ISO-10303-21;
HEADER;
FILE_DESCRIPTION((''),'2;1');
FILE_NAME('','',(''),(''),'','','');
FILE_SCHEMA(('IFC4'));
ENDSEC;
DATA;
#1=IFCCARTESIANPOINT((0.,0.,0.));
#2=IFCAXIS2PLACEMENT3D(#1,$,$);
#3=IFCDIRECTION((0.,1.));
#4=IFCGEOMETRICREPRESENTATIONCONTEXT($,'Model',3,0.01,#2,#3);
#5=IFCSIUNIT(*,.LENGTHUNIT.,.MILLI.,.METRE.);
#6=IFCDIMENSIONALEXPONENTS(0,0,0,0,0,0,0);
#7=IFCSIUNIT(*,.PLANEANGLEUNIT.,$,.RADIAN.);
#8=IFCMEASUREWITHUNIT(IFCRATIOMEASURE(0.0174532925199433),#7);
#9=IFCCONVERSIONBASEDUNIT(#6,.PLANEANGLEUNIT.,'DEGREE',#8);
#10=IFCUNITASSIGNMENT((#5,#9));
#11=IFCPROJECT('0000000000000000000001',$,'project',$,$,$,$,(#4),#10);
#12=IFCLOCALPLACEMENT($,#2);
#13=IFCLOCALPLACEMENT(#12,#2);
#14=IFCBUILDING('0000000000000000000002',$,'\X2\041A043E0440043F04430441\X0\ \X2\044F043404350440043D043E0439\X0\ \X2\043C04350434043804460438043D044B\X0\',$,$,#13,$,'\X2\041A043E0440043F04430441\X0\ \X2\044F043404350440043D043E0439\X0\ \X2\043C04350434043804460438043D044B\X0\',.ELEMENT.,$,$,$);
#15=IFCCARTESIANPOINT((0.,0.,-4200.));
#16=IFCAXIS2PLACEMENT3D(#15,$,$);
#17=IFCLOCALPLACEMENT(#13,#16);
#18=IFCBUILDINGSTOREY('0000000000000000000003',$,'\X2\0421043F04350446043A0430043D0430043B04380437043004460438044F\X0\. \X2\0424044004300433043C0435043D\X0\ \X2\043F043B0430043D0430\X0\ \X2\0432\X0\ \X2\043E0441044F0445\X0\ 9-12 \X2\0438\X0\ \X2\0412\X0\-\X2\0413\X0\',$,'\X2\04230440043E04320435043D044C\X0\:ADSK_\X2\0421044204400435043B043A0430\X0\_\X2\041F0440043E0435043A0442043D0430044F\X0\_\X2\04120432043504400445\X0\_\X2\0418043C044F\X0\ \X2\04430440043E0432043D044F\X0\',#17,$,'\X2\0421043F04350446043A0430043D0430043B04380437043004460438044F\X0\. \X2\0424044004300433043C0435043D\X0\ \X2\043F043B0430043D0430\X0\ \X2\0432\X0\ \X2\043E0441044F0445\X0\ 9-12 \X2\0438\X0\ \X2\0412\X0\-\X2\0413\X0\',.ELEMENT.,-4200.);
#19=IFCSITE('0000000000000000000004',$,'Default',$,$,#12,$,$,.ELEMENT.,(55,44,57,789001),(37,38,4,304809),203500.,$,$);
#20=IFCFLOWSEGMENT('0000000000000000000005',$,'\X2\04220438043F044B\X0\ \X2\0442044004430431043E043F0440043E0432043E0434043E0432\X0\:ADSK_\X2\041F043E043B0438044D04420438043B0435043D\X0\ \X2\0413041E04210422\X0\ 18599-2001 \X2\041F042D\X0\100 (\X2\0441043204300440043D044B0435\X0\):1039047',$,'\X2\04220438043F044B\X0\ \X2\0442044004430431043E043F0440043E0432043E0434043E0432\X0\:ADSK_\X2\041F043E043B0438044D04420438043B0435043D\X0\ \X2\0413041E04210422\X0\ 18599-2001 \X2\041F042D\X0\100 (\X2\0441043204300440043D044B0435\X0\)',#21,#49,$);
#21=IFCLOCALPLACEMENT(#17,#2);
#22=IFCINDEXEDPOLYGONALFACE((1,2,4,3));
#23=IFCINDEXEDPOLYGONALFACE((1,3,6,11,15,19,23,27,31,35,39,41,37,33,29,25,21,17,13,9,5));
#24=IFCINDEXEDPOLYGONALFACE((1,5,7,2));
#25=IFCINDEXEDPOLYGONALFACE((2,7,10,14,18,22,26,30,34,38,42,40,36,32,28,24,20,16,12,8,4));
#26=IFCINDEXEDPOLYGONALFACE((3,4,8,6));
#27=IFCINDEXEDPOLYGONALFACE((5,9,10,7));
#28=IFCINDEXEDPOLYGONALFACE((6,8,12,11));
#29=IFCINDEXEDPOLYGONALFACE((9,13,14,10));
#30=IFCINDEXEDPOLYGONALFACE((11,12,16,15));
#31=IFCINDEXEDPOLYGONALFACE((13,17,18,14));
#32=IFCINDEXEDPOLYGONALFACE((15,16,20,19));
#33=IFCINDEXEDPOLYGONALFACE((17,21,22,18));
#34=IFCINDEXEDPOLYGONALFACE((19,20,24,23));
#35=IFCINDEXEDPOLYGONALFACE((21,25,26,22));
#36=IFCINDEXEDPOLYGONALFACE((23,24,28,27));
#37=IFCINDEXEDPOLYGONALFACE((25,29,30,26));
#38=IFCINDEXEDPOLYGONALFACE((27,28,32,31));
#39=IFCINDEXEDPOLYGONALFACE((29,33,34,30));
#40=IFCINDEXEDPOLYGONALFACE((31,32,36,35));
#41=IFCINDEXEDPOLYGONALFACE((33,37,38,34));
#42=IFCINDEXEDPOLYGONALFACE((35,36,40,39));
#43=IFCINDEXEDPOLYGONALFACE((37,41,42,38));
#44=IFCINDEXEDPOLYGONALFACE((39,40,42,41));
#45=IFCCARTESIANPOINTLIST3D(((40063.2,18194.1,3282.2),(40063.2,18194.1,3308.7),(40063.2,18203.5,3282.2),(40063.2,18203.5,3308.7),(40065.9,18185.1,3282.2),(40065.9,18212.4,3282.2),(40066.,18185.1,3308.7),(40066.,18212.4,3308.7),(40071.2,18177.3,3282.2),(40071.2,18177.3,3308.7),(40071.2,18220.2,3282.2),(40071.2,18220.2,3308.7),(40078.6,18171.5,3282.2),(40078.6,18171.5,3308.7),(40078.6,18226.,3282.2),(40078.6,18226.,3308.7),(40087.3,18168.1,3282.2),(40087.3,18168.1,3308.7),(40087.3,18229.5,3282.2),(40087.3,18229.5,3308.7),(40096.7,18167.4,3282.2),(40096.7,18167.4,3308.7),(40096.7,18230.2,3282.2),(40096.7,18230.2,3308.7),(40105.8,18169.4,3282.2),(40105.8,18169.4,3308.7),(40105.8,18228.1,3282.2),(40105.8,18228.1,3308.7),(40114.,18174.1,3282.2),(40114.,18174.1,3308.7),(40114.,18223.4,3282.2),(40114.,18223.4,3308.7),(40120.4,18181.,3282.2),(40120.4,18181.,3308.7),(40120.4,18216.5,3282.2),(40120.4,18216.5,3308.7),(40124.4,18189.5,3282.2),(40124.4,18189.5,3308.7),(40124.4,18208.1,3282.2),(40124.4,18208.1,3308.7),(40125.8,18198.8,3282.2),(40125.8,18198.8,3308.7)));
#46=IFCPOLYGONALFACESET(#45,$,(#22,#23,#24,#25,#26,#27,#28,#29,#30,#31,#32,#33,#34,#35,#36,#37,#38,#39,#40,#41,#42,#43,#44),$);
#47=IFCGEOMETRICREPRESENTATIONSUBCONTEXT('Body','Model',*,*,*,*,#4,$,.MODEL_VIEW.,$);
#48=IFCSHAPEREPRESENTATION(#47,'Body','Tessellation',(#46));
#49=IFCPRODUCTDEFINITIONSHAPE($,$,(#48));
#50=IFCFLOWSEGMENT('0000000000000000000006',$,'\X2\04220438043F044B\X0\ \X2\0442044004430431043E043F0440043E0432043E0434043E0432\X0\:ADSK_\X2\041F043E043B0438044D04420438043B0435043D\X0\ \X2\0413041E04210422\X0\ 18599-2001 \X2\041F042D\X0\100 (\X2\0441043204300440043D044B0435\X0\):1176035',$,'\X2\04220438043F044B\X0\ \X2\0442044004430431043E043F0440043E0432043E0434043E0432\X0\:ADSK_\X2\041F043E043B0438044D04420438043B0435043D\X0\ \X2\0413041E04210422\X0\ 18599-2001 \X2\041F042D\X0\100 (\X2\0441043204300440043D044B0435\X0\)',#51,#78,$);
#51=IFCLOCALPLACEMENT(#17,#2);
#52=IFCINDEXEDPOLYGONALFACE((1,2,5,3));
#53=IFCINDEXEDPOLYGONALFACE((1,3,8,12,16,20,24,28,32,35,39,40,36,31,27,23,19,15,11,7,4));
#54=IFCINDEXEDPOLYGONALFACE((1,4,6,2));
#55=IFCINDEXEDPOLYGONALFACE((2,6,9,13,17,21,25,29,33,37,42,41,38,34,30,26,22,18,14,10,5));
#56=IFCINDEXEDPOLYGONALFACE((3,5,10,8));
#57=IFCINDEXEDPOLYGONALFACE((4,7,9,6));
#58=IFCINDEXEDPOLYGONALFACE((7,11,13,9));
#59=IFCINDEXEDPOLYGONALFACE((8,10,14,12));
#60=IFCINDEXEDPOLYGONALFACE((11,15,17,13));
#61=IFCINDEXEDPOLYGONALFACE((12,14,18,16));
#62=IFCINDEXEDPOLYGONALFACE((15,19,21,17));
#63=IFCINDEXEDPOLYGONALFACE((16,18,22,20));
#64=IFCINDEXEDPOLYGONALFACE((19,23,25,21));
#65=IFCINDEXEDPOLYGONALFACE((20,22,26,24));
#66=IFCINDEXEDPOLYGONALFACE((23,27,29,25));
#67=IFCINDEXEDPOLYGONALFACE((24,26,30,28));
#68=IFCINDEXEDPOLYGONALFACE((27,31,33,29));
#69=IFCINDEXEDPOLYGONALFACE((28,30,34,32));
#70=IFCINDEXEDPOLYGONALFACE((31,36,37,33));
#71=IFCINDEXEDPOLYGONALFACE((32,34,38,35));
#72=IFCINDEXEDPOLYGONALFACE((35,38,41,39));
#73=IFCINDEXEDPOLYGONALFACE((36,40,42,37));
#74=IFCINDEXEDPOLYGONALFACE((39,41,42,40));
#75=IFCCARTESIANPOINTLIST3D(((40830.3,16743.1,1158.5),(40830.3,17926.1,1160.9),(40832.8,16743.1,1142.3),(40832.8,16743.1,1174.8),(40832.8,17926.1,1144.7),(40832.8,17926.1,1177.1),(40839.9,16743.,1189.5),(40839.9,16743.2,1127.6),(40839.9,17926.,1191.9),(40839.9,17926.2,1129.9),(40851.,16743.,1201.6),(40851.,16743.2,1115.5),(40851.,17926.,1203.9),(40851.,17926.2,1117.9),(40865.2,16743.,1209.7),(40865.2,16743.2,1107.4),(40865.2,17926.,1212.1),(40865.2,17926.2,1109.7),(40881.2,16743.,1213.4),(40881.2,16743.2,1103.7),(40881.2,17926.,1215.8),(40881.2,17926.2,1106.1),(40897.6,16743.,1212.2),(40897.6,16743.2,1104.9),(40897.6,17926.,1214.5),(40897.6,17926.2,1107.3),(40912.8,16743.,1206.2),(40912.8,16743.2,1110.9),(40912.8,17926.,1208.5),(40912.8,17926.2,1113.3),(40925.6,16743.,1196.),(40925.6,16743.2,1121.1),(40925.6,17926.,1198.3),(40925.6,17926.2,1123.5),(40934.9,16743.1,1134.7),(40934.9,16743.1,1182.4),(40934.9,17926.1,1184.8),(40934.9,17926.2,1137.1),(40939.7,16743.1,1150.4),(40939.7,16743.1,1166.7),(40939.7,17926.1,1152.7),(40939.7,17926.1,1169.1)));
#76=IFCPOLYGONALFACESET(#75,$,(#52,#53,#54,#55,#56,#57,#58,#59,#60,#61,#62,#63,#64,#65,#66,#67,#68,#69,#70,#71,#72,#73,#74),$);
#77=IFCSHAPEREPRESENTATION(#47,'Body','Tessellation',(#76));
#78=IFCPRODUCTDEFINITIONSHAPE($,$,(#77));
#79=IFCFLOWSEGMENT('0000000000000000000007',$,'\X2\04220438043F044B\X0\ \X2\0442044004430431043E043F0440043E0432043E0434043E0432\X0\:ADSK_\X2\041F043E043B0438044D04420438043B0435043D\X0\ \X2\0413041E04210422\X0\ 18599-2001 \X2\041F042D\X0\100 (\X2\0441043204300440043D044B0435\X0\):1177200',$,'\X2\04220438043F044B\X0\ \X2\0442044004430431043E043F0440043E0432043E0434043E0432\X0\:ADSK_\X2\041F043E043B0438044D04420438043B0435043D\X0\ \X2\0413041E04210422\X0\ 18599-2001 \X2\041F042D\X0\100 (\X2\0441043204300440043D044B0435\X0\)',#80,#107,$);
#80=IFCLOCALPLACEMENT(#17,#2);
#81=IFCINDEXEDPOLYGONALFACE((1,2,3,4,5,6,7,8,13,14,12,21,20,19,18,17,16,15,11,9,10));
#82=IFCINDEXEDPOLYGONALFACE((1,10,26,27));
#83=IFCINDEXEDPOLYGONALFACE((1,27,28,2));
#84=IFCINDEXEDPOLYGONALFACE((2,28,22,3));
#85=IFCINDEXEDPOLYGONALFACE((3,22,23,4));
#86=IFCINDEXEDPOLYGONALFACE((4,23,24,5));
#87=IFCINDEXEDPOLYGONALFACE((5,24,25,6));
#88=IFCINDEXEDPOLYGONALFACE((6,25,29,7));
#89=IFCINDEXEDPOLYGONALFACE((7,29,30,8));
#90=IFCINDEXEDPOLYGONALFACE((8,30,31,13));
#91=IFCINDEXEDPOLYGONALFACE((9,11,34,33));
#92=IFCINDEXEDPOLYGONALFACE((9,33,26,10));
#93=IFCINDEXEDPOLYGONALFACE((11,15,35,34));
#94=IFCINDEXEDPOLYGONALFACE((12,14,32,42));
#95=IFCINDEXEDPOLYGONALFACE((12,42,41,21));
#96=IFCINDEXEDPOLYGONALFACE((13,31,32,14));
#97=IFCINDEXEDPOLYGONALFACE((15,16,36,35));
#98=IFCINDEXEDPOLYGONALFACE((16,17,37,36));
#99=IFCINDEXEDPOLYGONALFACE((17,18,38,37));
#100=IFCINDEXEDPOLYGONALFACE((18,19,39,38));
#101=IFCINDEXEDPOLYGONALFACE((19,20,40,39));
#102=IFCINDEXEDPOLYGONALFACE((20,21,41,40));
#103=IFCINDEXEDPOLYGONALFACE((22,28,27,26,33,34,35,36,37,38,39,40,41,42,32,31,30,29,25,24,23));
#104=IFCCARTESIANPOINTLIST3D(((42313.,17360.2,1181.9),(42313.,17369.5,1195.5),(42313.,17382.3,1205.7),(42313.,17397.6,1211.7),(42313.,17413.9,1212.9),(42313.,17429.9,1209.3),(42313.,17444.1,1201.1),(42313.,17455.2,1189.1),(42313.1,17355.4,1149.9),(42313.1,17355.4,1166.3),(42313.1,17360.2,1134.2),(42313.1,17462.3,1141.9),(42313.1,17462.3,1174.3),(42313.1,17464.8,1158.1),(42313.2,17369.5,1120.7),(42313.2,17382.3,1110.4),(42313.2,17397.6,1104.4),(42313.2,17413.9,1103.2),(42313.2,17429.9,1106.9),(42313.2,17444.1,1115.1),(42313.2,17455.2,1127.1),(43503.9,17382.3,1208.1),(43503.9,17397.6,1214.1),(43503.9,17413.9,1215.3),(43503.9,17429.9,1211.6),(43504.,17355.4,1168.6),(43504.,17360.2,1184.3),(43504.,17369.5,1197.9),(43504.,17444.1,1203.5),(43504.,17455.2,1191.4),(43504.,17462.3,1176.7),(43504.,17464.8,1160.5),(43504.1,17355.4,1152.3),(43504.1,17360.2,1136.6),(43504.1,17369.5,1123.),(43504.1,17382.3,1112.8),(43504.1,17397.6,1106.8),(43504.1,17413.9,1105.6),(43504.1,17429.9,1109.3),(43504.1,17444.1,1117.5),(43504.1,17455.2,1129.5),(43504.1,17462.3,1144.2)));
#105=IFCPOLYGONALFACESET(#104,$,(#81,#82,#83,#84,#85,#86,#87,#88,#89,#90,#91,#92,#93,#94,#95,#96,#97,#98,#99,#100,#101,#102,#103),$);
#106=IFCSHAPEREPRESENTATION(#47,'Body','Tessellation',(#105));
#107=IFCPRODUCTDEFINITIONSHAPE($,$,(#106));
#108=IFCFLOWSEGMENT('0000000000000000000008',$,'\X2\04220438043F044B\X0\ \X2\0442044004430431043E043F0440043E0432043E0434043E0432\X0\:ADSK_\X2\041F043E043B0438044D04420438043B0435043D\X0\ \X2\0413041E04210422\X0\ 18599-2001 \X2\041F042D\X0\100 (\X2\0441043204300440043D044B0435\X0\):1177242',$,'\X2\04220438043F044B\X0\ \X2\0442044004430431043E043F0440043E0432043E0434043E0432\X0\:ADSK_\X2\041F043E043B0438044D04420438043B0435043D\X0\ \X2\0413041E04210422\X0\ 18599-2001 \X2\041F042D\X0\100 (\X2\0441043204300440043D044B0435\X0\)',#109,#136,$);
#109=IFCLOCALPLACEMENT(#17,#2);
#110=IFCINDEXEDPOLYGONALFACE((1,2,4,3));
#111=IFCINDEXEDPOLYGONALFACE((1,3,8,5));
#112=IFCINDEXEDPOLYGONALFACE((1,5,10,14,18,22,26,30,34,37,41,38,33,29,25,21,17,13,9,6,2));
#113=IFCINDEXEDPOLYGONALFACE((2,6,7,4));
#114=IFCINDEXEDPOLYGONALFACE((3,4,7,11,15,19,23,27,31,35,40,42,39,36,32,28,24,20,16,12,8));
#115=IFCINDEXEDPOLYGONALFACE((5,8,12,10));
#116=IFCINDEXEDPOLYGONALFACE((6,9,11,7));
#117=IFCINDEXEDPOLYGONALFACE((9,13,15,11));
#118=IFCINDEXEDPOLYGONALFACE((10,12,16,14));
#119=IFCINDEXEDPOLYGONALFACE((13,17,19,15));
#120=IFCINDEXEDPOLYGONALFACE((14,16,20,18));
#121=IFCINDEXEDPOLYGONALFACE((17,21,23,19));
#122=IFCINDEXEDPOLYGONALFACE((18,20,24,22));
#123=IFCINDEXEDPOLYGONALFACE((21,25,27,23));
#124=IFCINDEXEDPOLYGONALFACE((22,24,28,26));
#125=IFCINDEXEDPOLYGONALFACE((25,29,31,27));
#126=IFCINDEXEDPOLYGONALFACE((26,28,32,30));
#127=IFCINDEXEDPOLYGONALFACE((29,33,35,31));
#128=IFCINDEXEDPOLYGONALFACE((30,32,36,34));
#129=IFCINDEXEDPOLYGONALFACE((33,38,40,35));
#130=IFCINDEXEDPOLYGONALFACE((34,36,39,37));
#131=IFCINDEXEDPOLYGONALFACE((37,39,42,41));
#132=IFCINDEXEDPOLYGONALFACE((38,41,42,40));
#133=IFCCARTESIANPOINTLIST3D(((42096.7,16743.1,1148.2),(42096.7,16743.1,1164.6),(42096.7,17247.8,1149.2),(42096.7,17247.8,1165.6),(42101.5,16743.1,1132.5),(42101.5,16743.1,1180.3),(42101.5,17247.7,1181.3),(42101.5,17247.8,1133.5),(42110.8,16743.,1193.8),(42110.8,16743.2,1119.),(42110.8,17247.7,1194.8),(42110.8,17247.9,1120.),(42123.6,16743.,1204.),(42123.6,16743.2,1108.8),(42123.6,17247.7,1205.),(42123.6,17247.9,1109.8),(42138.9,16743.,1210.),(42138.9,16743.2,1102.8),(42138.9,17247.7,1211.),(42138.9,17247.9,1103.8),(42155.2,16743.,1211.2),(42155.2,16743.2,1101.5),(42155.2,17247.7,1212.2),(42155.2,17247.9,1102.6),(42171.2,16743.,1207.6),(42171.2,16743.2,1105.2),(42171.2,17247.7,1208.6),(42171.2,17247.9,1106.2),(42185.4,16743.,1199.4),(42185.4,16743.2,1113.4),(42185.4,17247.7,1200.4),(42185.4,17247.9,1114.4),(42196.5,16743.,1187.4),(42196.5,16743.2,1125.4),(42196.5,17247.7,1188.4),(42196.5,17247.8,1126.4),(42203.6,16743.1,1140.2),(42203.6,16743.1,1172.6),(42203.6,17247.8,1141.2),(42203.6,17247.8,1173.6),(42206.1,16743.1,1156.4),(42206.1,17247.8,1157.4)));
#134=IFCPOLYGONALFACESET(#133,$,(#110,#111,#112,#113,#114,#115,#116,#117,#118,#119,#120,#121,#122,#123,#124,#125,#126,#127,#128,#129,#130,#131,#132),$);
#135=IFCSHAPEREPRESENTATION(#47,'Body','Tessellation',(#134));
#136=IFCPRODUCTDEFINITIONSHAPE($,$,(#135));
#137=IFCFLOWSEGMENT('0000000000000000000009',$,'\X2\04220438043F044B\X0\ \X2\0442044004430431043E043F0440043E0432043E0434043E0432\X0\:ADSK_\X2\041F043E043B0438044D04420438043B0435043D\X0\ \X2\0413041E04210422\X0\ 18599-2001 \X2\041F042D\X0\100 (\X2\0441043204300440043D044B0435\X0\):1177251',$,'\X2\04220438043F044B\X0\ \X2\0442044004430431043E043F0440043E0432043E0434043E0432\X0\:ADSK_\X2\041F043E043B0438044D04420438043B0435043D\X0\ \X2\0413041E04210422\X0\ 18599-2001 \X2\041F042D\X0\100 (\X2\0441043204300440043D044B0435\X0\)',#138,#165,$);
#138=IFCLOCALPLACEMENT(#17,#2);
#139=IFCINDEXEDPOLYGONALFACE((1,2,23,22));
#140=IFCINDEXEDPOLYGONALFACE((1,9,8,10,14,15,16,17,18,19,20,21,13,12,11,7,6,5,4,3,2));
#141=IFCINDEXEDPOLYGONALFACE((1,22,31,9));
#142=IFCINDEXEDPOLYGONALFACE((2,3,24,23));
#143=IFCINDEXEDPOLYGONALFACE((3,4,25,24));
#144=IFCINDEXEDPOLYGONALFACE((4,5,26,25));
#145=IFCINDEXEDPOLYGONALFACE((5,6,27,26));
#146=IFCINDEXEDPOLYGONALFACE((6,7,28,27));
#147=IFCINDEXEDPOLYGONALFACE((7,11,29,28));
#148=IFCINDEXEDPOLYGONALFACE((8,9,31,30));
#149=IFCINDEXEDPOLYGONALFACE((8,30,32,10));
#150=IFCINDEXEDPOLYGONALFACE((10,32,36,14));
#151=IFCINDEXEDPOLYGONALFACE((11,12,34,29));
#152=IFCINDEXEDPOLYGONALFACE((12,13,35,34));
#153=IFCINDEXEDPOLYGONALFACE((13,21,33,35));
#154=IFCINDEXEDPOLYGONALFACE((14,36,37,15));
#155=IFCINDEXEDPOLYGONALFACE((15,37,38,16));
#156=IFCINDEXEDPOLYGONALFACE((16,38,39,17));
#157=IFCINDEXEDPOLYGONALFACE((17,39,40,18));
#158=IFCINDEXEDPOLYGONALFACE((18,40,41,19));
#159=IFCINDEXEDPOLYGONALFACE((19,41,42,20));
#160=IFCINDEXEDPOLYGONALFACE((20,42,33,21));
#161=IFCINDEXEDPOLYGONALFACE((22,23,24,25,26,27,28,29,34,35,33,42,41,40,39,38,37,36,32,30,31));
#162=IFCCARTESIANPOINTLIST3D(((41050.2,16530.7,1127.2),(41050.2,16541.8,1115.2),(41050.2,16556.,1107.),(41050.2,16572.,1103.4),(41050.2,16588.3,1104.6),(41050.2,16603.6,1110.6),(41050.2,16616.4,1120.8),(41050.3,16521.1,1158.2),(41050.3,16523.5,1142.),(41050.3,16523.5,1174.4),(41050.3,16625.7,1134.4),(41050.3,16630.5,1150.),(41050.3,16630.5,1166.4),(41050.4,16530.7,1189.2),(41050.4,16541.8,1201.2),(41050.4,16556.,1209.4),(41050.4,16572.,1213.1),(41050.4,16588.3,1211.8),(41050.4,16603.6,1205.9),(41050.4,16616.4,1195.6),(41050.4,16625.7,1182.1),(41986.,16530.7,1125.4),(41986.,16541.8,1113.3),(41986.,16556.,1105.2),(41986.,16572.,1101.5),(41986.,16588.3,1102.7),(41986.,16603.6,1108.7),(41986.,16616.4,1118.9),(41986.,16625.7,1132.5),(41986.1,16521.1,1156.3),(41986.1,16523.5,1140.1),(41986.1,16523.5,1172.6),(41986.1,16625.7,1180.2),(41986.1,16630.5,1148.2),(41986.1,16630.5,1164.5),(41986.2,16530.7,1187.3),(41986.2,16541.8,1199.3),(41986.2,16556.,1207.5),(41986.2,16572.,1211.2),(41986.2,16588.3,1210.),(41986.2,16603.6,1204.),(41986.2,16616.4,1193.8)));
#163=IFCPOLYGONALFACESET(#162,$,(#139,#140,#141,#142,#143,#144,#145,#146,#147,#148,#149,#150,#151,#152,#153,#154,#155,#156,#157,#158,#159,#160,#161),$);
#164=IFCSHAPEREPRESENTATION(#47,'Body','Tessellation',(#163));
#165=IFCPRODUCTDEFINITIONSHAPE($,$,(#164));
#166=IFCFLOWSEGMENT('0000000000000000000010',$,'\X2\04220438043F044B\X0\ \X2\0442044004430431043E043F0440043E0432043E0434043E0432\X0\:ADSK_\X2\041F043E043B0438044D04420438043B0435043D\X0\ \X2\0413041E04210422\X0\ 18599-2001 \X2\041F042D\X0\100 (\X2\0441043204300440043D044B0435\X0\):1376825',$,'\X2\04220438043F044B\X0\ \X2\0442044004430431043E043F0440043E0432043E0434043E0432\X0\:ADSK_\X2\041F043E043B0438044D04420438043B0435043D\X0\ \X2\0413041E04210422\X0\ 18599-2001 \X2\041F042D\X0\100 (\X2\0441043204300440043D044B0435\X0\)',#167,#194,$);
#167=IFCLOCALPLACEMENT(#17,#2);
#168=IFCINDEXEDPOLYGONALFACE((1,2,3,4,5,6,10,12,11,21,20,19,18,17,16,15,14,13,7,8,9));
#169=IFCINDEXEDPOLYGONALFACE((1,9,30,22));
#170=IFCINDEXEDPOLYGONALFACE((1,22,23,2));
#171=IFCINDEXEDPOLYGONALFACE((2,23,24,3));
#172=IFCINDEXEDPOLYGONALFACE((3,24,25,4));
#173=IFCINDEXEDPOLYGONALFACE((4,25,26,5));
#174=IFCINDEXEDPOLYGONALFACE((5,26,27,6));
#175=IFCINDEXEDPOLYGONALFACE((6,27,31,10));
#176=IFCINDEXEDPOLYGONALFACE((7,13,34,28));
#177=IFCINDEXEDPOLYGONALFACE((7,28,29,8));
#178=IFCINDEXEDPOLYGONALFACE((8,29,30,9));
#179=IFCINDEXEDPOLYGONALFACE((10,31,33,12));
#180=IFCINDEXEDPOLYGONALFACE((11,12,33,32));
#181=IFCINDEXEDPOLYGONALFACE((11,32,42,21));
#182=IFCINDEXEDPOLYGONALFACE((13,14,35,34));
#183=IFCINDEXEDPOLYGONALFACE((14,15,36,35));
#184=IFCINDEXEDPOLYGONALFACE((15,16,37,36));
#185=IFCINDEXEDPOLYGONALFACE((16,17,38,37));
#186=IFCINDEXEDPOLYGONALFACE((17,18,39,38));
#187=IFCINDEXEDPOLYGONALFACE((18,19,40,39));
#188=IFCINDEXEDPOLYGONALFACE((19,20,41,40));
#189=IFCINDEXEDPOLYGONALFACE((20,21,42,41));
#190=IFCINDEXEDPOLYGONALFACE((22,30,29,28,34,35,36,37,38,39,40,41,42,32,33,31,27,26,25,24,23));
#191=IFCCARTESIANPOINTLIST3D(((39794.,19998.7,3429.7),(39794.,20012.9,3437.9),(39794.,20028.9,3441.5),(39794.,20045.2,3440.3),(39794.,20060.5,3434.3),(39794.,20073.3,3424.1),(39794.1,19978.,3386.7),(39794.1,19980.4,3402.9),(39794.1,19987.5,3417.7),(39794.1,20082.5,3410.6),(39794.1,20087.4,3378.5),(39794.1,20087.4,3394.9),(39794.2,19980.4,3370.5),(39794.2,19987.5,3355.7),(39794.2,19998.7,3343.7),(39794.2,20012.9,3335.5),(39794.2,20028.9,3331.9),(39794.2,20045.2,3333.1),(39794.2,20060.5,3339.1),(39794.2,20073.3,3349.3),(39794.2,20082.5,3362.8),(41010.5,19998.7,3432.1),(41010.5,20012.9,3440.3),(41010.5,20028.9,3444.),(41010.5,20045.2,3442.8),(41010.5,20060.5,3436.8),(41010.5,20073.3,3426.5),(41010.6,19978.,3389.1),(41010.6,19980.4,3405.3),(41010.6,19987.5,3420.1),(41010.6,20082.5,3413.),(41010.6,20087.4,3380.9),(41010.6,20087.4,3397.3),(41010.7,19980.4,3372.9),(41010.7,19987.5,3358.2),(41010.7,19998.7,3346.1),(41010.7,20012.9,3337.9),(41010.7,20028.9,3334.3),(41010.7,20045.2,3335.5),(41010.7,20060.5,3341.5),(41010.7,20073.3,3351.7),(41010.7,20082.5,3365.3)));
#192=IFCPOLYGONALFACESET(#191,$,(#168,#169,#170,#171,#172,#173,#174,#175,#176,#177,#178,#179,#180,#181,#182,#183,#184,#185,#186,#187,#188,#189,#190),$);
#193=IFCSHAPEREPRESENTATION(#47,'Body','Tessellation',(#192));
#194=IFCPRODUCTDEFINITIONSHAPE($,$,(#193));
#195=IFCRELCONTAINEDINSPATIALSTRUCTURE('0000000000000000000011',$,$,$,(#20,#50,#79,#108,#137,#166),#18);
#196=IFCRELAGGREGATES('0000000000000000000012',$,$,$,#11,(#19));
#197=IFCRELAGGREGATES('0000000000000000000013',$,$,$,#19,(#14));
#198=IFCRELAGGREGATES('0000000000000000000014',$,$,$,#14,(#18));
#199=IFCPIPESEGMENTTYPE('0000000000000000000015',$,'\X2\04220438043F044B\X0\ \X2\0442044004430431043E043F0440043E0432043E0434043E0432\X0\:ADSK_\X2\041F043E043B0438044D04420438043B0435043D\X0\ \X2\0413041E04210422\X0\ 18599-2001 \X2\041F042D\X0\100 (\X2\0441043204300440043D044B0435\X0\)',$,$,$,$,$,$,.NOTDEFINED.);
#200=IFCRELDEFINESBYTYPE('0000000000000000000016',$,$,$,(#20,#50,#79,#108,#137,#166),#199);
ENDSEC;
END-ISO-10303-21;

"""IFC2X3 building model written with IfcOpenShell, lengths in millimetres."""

from ifc_helpers import new_model, entity, si_unit, converted_unit, direction, frame, origin, origin_2d_with_axis, place, context, subcontext, project, spatial, circle, extrude, type_object, element, save


model = new_model("IFC2X3")

# Units and contexts
model_context = context("Model", 3, precision=0.01, world=origin(), true_north=direction((0.0, 1.0)))
body_context = subcontext(model_context, "Body", "Model", "MODEL_VIEW")
ifc_project = project(units=[si_unit("LENGTHUNIT", "METRE", prefix="MILLI"), converted_unit("PLANEANGLEUNIT", "DEGREE", entity("IfcRatioMeasure", 0.0174532925199433), si_unit("PLANEANGLEUNIT", "RADIAN"), dimensions=[0, 0, 0, 0, 0, 0, 0])], contexts=[model_context])

# Site, building, storey
site_placement = place(None, origin())
site = spatial("IfcSite", under=ifc_project, at=site_placement, Name="Default", CompositionType="ELEMENT", RefLatitude=(55, 44, 57, 789001), RefLongitude=(37, 38, 4, 304809), RefElevation=203500.0)
building_placement = place(site_placement, origin())
building = spatial("IfcBuilding", under=site, at=building_placement, Name="Корпус ядерной медицины", LongName="Корпус ядерной медицины", CompositionType="ELEMENT")
storey_placement = place(building_placement, frame((0.0, 0.0, -4200.0)))
storey = spatial("IfcBuildingStorey", under=building, at=storey_placement, Name="Спецканализация. Фрагмен плана в осях 9-12 и В-Г", ObjectType="Уровень:ADSK_Стрелка_Проектная_Вверх_Имя уровня", LongName="Спецканализация. Фрагмен плана в осях 9-12 и В-Г", CompositionType="ELEMENT", Elevation=-4200.0)

# Flow segments
pipe_segment_type = type_object("IfcPipeSegmentType", Name="Типы трубопроводов:ADSK_Полиэтилен ГОСТ 18599-2001 ПЭ100 (сварные)", PredefinedType="NOTDEFINED")
flow_segment_1_placement = place(storey_placement, frame((40061.2, 18165.7, 3282.2)))
element("IfcFlowSegment", 1, at=flow_segment_1_placement, inside=storey, type_object=pipe_segment_type, Name="Типы трубопроводов:ADSK_Полиэтилен ГОСТ 18599-2001 ПЭ100 (сварные):1039047", ObjectType="Типы трубопроводов:ADSK_Полиэтилен ГОСТ 18599-2001 ПЭ100 (сварные)", context=body_context, shape_type="SweptSolid", body=[
    extrude(circle(Radius=31.5, at=origin_2d_with_axis()), frame((33.1, 33.1, 0.0), z_axis=(0.000039, -0.00005, 1.0), x_axis=(1.0, 0.0, -0.000039)), (0.0, 0.0, 1.0), 26.5),
])
flow_segment_2_placement = place(storey_placement, frame((40828.7, 16743.0, 1102.0)))
element("IfcFlowSegment", 2, at=flow_segment_2_placement, inside=storey, type_object=pipe_segment_type, Name="Типы трубопроводов:ADSK_Полиэтилен ГОСТ 18599-2001 ПЭ100 (сварные):1176035", ObjectType="Типы трубопроводов:ADSK_Полиэтилен ГОСТ 18599-2001 ПЭ100 (сварные)", context=body_context, shape_type="SweptSolid", body=[
    extrude(circle(Radius=55.0, at=origin_2d_with_axis()), frame((56.6, 0.1, 56.6), z_axis=(0.0, 0.999998, 0.002), x_axis=(-1.0, 0.0, 0.0)), (0.0, 0.0, 1.0), 1183.0),
])
flow_segment_3_placement = place(storey_placement, frame((42313.0, 17353.2, 1101.5)))
element("IfcFlowSegment", 3, at=flow_segment_3_placement, inside=storey, type_object=pipe_segment_type, Name="Типы трубопроводов:ADSK_Полиэтилен ГОСТ 18599-2001 ПЭ100 (сварные):1177200", ObjectType="Типы трубопроводов:ADSK_Полиэтилен ГОСТ 18599-2001 ПЭ100 (сварные)", context=body_context, shape_type="SweptSolid", body=[
    extrude(circle(Radius=55.0, at=origin_2d_with_axis()), frame((0.1, 56.6, 56.6), z_axis=(0.999998, 0.0, 0.002), x_axis=(0.0, 1.0, 0.0)), (0.0, 0.0, 1.0), 1191.0),
])
flow_segment_4_placement = place(storey_placement, frame((42094.5, 16743.0, 1099.8)))
element("IfcFlowSegment", 4, at=flow_segment_4_placement, inside=storey, type_object=pipe_segment_type, Name="Типы трубопроводов:ADSK_Полиэтилен ГОСТ 18599-2001 ПЭ100 (сварные):1177242", ObjectType="Типы трубопроводов:ADSK_Полиэтилен ГОСТ 18599-2001 ПЭ100 (сварные)", context=body_context, shape_type="SweptSolid", body=[
    extrude(circle(Radius=55.0, at=origin_2d_with_axis()), frame((56.6, 0.1, 56.6), z_axis=(-0.000001, 0.999998, 0.002), x_axis=(1.0, 0.000001, 0.0)), (0.0, 0.0, 1.0), 504.7),
])
flow_segment_5_placement = place(storey_placement, frame((41050.2, 16519.5, 1099.8)))
element("IfcFlowSegment", 5, at=flow_segment_5_placement, inside=storey, type_object=pipe_segment_type, Name="Типы трубопроводов:ADSK_Полиэтилен ГОСТ 18599-2001 ПЭ100 (сварные):1177251", ObjectType="Типы трубопроводов:ADSK_Полиэтилен ГОСТ 18599-2001 ПЭ100 (сварные)", context=body_context, shape_type="SweptSolid", body=[
    extrude(circle(Radius=55.0, at=origin_2d_with_axis()), frame((0.1, 56.6, 58.5), z_axis=(0.999998, 0.0, -0.002), x_axis=(0.0, -1.0, 0.0)), (0.0, 0.0, 1.0), 935.8),
])
flow_segment_6_placement = place(storey_placement, frame((39794.0, 19976.4, 3330.1)))
element("IfcFlowSegment", 6, at=flow_segment_6_placement, inside=storey, type_object=pipe_segment_type, Name="Типы трубопроводов:ADSK_Полиэтилен ГОСТ 18599-2001 ПЭ100 (сварные):1376825", ObjectType="Типы трубопроводов:ADSK_Полиэтилен ГОСТ 18599-2001 ПЭ100 (сварные)", context=body_context, shape_type="SweptSolid", body=[
    extrude(circle(Radius=55.0, at=origin_2d_with_axis()), frame((0.1, 56.6, 56.6), z_axis=(0.999998, 0.0, 0.002), x_axis=(0.0, -1.0, 0.0)), (0.0, 0.0, 1.0), 1216.5),
])

save(model, "model.ifc")
